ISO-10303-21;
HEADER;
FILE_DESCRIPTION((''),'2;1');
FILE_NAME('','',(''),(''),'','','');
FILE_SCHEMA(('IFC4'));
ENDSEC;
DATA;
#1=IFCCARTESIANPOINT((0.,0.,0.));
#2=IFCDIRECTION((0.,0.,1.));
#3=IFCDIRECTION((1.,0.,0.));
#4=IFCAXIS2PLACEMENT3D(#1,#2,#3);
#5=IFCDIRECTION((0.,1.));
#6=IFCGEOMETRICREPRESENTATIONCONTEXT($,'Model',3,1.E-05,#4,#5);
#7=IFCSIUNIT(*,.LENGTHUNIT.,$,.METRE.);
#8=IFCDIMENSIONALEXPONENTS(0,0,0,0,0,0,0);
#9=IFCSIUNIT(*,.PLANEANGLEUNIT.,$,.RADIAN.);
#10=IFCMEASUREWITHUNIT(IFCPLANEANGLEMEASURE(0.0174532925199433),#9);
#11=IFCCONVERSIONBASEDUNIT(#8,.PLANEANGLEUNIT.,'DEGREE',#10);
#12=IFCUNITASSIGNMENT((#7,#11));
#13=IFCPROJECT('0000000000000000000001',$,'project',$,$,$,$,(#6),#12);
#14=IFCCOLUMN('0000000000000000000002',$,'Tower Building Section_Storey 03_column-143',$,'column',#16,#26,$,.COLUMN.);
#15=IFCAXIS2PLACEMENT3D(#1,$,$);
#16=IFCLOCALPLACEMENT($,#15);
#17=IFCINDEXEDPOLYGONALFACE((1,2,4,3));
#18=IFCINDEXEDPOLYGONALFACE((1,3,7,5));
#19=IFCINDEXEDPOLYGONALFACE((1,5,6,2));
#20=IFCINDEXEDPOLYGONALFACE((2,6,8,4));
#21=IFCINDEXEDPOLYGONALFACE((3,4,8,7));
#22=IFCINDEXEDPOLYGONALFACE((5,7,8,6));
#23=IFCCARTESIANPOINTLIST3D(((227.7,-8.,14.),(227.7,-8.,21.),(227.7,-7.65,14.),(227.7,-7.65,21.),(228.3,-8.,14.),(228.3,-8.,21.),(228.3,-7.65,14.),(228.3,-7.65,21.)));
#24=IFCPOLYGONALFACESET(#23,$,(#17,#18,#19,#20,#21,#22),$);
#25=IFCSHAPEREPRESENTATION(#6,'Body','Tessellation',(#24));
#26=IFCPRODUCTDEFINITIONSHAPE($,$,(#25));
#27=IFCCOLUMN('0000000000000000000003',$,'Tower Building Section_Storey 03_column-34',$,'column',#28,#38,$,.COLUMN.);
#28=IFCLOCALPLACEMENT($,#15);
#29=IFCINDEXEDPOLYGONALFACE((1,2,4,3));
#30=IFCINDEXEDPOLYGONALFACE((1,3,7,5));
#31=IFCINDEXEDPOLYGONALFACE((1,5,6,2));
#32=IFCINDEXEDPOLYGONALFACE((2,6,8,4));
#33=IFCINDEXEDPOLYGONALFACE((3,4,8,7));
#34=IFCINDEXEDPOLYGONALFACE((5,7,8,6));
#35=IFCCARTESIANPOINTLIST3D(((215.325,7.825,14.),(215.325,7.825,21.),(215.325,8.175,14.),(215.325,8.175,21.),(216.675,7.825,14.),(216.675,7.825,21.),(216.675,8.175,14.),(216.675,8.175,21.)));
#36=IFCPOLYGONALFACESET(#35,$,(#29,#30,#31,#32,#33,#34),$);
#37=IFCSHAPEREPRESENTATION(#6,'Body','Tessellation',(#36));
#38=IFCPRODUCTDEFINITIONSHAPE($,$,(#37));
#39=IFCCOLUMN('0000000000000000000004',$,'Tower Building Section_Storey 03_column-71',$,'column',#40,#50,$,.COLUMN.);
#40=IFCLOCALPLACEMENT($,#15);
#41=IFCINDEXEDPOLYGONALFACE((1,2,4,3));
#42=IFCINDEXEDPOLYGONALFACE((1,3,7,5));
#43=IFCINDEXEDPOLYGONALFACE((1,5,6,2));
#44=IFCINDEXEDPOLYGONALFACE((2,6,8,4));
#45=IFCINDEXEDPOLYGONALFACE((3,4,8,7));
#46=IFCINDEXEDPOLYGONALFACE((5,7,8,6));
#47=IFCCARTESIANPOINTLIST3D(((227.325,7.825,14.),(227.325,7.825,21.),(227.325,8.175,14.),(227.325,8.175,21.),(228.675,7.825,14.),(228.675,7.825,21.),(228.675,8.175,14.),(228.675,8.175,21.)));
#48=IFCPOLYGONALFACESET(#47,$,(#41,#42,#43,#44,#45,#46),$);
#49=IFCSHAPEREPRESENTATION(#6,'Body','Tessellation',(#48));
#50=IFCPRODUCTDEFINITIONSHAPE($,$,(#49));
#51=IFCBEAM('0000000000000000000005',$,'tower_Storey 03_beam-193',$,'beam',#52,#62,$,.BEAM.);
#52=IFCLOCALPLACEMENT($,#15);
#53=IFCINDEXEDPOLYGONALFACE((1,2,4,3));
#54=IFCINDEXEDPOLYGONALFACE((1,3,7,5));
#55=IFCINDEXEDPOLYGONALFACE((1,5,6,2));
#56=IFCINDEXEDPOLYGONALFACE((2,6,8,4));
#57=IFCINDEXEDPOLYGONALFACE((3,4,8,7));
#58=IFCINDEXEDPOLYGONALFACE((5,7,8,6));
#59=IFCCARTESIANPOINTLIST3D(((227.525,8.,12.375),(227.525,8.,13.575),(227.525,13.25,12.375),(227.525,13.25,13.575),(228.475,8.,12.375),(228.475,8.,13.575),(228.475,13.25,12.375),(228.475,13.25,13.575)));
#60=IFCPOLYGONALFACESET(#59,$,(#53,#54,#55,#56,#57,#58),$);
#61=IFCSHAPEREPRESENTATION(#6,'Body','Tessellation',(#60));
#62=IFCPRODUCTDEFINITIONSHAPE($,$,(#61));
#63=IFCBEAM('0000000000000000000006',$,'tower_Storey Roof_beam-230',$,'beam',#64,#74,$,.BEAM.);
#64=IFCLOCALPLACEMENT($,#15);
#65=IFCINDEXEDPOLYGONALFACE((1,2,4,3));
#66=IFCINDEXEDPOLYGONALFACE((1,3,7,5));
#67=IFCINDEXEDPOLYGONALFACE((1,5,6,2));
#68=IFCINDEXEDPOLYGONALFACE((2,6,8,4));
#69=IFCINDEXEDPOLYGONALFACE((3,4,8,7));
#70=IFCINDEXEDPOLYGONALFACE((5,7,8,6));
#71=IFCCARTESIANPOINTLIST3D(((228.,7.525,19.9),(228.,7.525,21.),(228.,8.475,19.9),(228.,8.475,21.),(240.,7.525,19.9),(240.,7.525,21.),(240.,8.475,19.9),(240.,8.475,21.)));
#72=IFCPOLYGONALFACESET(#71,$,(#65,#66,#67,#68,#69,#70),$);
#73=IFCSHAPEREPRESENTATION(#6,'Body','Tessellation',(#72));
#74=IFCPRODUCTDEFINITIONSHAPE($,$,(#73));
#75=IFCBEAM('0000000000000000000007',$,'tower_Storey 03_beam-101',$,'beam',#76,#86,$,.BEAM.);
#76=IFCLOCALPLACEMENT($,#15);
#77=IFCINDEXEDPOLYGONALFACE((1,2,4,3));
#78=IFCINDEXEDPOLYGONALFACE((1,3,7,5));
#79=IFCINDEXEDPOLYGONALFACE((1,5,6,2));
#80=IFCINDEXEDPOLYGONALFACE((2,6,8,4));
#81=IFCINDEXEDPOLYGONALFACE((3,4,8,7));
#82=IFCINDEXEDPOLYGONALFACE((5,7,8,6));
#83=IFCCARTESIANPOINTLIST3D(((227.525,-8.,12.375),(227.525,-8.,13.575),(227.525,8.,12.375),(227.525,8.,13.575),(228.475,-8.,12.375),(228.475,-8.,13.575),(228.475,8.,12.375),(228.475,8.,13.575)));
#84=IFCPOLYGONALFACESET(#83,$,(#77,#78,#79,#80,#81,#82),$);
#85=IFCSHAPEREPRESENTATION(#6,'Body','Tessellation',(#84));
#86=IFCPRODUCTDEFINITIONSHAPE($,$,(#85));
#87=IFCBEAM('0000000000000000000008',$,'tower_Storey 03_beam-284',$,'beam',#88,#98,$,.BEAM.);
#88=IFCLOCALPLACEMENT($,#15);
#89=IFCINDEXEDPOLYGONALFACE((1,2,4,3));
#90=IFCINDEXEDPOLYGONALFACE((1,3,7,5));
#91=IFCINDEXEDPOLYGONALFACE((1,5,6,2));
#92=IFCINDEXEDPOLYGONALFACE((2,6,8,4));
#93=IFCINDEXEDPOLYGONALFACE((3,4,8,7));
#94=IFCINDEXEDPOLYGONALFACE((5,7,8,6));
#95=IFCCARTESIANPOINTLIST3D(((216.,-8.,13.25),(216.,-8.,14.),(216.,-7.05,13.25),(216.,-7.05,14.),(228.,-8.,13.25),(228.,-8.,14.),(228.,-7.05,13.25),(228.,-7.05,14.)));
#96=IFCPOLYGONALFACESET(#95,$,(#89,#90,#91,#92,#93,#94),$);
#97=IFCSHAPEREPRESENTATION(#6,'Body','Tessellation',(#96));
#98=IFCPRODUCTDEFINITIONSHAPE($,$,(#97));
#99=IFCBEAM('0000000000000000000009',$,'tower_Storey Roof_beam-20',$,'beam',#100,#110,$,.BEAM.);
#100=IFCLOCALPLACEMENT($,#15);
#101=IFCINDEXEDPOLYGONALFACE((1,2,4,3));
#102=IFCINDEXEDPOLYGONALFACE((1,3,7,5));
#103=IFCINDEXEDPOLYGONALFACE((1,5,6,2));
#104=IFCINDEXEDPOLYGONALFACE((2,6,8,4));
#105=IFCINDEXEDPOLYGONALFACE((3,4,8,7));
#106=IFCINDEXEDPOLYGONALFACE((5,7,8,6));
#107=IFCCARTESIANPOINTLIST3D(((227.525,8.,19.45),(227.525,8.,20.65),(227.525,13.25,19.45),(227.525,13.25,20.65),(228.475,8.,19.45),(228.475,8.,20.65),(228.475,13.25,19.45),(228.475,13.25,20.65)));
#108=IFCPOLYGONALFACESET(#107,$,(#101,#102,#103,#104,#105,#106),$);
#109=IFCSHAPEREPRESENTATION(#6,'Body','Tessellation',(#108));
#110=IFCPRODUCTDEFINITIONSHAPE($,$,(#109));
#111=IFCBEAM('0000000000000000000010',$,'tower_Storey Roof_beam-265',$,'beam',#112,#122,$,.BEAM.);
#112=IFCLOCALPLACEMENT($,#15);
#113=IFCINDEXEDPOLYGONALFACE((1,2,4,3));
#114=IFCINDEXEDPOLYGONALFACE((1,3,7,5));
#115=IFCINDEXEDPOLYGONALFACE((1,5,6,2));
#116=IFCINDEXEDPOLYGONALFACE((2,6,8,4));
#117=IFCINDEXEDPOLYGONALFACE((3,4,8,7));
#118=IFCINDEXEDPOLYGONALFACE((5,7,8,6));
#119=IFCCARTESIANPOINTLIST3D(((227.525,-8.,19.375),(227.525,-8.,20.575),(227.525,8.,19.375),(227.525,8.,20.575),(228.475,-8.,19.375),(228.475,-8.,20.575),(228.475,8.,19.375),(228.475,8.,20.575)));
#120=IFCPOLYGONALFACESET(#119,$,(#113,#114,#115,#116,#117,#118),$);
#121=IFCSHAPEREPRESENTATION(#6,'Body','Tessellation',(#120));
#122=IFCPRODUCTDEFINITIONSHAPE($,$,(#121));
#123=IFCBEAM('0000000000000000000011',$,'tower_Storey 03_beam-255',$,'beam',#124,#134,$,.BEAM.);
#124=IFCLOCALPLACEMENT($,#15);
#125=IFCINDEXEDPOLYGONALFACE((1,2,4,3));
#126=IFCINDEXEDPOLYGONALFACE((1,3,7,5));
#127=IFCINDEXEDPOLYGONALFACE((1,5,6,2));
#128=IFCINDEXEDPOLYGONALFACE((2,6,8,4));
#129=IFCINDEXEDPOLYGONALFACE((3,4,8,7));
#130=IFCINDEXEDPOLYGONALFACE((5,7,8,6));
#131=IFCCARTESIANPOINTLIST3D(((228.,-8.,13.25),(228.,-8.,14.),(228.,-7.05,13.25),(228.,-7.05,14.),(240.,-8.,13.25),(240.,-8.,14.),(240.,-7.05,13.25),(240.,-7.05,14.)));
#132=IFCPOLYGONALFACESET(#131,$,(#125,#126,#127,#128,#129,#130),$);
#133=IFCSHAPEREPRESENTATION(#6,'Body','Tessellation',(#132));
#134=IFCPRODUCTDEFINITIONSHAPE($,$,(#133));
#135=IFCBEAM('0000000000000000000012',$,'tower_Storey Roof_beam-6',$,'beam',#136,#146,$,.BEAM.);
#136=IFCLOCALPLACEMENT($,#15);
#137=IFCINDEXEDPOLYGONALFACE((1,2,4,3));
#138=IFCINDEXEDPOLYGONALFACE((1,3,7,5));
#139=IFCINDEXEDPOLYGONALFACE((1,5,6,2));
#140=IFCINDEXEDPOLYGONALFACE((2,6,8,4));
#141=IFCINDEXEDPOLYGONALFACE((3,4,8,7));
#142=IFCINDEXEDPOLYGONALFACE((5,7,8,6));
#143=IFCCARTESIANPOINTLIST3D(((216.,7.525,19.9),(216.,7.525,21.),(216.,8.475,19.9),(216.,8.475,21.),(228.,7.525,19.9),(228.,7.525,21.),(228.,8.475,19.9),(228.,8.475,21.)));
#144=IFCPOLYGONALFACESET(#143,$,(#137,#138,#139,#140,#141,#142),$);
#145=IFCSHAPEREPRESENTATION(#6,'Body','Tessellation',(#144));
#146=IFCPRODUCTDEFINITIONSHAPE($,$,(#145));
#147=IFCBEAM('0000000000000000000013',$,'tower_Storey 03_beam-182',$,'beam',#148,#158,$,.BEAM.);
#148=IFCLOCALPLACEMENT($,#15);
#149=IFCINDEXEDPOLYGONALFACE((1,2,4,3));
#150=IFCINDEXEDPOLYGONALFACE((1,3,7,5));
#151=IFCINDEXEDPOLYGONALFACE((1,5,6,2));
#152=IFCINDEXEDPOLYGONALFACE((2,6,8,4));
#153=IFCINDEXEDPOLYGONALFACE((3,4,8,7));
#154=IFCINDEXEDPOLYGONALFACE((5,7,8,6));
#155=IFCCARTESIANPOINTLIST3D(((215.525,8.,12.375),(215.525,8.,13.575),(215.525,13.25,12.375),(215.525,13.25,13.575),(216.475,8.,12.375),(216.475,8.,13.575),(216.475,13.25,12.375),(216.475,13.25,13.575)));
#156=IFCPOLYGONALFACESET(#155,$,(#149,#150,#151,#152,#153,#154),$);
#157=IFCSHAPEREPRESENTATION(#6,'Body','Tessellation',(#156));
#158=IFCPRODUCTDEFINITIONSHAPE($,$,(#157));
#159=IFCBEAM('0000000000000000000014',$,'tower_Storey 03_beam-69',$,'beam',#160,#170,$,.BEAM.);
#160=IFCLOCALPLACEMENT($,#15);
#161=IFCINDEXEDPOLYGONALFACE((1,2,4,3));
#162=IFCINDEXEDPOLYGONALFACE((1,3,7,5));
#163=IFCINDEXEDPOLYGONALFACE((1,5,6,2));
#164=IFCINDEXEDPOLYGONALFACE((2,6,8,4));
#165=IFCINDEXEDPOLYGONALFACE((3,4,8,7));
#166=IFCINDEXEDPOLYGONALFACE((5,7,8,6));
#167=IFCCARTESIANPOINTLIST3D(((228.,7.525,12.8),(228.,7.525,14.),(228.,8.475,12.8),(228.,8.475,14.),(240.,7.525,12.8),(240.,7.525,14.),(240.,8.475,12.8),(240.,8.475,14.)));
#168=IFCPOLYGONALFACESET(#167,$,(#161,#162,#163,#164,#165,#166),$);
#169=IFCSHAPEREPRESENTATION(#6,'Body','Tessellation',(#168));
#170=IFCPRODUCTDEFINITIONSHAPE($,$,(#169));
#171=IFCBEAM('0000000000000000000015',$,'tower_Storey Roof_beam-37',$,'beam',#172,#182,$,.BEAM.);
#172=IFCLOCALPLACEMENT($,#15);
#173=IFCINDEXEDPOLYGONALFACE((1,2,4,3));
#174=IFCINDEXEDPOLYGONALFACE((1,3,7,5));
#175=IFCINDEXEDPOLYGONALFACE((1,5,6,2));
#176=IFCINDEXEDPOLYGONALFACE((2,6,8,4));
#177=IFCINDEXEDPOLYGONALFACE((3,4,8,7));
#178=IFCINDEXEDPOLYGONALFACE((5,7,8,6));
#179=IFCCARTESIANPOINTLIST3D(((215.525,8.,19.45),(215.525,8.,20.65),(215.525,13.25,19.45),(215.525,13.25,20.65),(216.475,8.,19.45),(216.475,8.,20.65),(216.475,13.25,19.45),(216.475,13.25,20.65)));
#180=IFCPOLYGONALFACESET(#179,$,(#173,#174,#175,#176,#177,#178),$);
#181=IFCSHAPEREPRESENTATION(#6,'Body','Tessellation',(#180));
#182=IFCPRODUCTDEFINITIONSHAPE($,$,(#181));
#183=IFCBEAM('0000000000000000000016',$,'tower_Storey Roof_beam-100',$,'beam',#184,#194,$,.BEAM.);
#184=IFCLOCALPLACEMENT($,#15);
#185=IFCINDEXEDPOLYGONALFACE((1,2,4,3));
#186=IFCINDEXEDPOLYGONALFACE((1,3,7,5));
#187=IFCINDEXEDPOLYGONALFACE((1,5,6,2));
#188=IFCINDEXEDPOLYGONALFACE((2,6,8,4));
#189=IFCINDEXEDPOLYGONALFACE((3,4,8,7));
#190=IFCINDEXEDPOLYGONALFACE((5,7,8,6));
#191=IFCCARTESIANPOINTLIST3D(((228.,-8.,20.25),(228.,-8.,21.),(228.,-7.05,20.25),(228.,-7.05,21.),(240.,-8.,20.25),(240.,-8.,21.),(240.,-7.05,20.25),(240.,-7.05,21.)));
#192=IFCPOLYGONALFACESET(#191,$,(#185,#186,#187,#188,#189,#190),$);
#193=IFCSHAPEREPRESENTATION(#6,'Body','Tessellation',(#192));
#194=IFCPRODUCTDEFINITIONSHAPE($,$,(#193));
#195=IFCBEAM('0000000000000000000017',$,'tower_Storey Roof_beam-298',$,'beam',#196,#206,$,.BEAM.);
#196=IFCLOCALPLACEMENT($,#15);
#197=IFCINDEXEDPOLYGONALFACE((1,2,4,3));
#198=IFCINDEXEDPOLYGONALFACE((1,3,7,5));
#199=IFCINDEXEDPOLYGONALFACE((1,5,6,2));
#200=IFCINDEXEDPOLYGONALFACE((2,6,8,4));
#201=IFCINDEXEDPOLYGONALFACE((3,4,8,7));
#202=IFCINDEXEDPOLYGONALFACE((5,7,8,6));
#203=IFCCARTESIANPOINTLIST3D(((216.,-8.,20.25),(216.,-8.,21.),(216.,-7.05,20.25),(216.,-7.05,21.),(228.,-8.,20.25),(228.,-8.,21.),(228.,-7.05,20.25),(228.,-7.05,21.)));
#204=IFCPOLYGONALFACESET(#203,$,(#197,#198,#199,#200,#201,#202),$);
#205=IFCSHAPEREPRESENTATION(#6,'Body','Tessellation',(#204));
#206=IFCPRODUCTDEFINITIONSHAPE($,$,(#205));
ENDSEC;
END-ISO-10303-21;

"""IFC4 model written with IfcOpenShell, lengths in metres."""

from ifc_helpers import new_model, entity, si_unit, converted_unit, direction, frame, origin_with_axes, place, context, project, polyline, outline, extrude, element, save


model = new_model("IFC4")

# Units and contexts
model_context = context("Model", 3, precision=1e-05, world=origin_with_axes(), true_north=direction((0.0, 1.0)))
ifc_project = project(units=[si_unit("LENGTHUNIT", "METRE"), converted_unit("PLANEANGLEUNIT", "DEGREE", entity("IfcPlaneAngleMeasure", 0.0174532925199433), si_unit("PLANEANGLEUNIT", "RADIAN"), dimensions=[0, 0, 0, 0, 0, 0, 0])], contexts=[model_context])

# Columns
placement_1 = place(None, origin_with_axes())
placement_2 = place(placement_1, frame((0.0, 0.0, 14.0), z_axis=(0.0, 0.0, 1.0), x_axis=(1.0, 0.0, 0.0)))
column_placement = place(placement_2, frame((228.0, -7.825, 0.0), z_axis=(0.0, 0.0, 1.0), x_axis=(1.0, 0.0, 0.0)))
element("IfcColumn", 1, at=column_placement, Name="Tower Building Section_Storey 03_column-143", ObjectType="column", PredefinedType="COLUMN", context=model_context, body=[
    extrude(outline(polyline([(-0.3, -0.175, 0.0), (0.3, -0.175, 0.0), (0.3, 0.175, 0.0), (-0.3, 0.175, 0.0), (-0.3, -0.175, 0.0)])), origin_with_axes(), (0.0, 0.0, 1.0), 7.0),
])
for number, where, z_axis, x_axis, name in (
    (2, (216.0, 8.0, 0.0), (0.0, 0.0, 1.0), (1.0, 0.0, 0.0), "Tower Building Section_Storey 03_column-34"),
    (3, (228.0, 8.0, 0.0), (0.0, 0.0, 1.0), (1.0, 0.0, 0.0), "Tower Building Section_Storey 03_column-71"),
):
    element("IfcColumn", number, at=place(placement_2, frame(where, z_axis=z_axis, x_axis=x_axis)), Name=name, ObjectType="column", PredefinedType="COLUMN", context=model_context, body=[
        extrude(outline(polyline([(-0.675, -0.175, 0.0), (0.675, -0.175, 0.0), (0.675, 0.175, 0.0), (-0.675, 0.175, 0.0), (-0.675, -0.175, 0.0)])), origin_with_axes(), (0.0, 0.0, 1.0), 7.0),
    ])

# Beams
beam_1_placement = place(placement_2, frame((228.0, 8.0, -1.025), z_axis=(0.0, 1.0, 0.0), x_axis=(-1.0, 0.0, 0.0)))
element("IfcBeam", 4, at=beam_1_placement, Name="tower_Storey 03_beam-193", ObjectType="beam", PredefinedType="BEAM", context=model_context, body=[
    extrude(outline(polyline([(0.475, 0.6, 0.0), (-0.475, 0.6, 0.0), (-0.475, -0.6, 0.0), (0.475, -0.6, 0.0), (0.475, 0.6, 0.0)])), origin_with_axes(), (0.0, 0.0, 1.0), 5.25),
])
placement_3 = place(placement_1, frame((0.0, 0.0, 21.0), z_axis=(0.0, 0.0, 1.0), x_axis=(1.0, 0.0, 0.0)))
beam_2_placement = place(placement_3, frame((228.0, 8.0, -0.55), z_axis=(1.0, 0.0, 0.0), x_axis=(0.0, 1.0, 0.0)))
element("IfcBeam", 5, at=beam_2_placement, Name="tower_Storey Roof_beam-230", ObjectType="beam", PredefinedType="BEAM", context=model_context, body=[
    extrude(outline(polyline([(0.475, 0.55, 0.0), (-0.475, 0.55, 0.0), (-0.475, -0.55, 0.0), (0.475, -0.55, 0.0), (0.475, 0.55, 0.0)])), origin_with_axes(), (0.0, 0.0, 1.0), 12.0),
])
beam_3_placement = place(placement_2, frame((228.0, -8.0, -1.025), z_axis=(0.0, 1.0, 0.0), x_axis=(-1.0, 0.0, 0.0)))
element("IfcBeam", 6, at=beam_3_placement, Name="tower_Storey 03_beam-101", ObjectType="beam", PredefinedType="BEAM", context=model_context, body=[
    extrude(outline(polyline([(0.475, 0.6, 0.0), (-0.475, 0.6, 0.0), (-0.475, -0.6, 0.0), (0.475, -0.6, 0.0), (0.475, 0.6, 0.0)])), origin_with_axes(), (0.0, 0.0, 1.0), 16.0),
])
beam_4_placement = place(placement_2, frame((216.0, -7.525, -0.375), z_axis=(1.0, 0.0, 0.0), x_axis=(0.0, 1.0, 0.0)))
element("IfcBeam", 7, at=beam_4_placement, Name="tower_Storey 03_beam-284", ObjectType="beam", PredefinedType="BEAM", context=model_context, body=[
    extrude(outline(polyline([(0.475, 0.375, 0.0), (-0.475, 0.375, 0.0), (-0.475, -0.375, 0.0), (0.475, -0.375, 0.0), (0.475, 0.375, 0.0)])), origin_with_axes(), (0.0, 0.0, 1.0), 12.0),
])
beam_5_placement = place(placement_3, frame((228.0, 8.0, -0.95), z_axis=(0.0, 1.0, 0.0), x_axis=(-1.0, 0.0, 0.0)))
element("IfcBeam", 8, at=beam_5_placement, Name="tower_Storey Roof_beam-20", ObjectType="beam", PredefinedType="BEAM", context=model_context, body=[
    extrude(outline(polyline([(0.475, 0.6, 0.0), (-0.475, 0.6, 0.0), (-0.475, -0.6, 0.0), (0.475, -0.6, 0.0), (0.475, 0.6, 0.0)])), origin_with_axes(), (0.0, 0.0, 1.0), 5.25),
])
beam_6_placement = place(placement_3, frame((228.0, -8.0, -1.025), z_axis=(0.0, 1.0, 0.0), x_axis=(-1.0, 0.0, 0.0)))
element("IfcBeam", 9, at=beam_6_placement, Name="tower_Storey Roof_beam-265", ObjectType="beam", PredefinedType="BEAM", context=model_context, body=[
    extrude(outline(polyline([(0.475, 0.6, 0.0), (-0.475, 0.6, 0.0), (-0.475, -0.6, 0.0), (0.475, -0.6, 0.0), (0.475, 0.6, 0.0)])), origin_with_axes(), (0.0, 0.0, 1.0), 16.0),
])
beam_7_placement = place(placement_2, frame((228.0, -7.525, -0.375), z_axis=(1.0, 0.0, 0.0), x_axis=(0.0, 1.0, 0.0)))
element("IfcBeam", 10, at=beam_7_placement, Name="tower_Storey 03_beam-255", ObjectType="beam", PredefinedType="BEAM", context=model_context, body=[
    extrude(outline(polyline([(0.475, 0.375, 0.0), (-0.475, 0.375, 0.0), (-0.475, -0.375, 0.0), (0.475, -0.375, 0.0), (0.475, 0.375, 0.0)])), origin_with_axes(), (0.0, 0.0, 1.0), 12.0),
])
beam_8_placement = place(placement_3, frame((216.0, 8.0, -0.55), z_axis=(1.0, 0.0, 0.0), x_axis=(0.0, 1.0, 0.0)))
element("IfcBeam", 11, at=beam_8_placement, Name="tower_Storey Roof_beam-6", ObjectType="beam", PredefinedType="BEAM", context=model_context, body=[
    extrude(outline(polyline([(0.475, 0.55, 0.0), (-0.475, 0.55, 0.0), (-0.475, -0.55, 0.0), (0.475, -0.55, 0.0), (0.475, 0.55, 0.0)])), origin_with_axes(), (0.0, 0.0, 1.0), 12.0),
])
beam_9_placement = place(placement_2, frame((216.0, 8.0, -1.025), z_axis=(0.0, 1.0, 0.0), x_axis=(-1.0, 0.0, 0.0)))
element("IfcBeam", 12, at=beam_9_placement, Name="tower_Storey 03_beam-182", ObjectType="beam", PredefinedType="BEAM", context=model_context, body=[
    extrude(outline(polyline([(0.475, 0.6, 0.0), (-0.475, 0.6, 0.0), (-0.475, -0.6, 0.0), (0.475, -0.6, 0.0), (0.475, 0.6, 0.0)])), origin_with_axes(), (0.0, 0.0, 1.0), 5.25),
])
beam_10_placement = place(placement_2, frame((228.0, 8.0, -0.6), z_axis=(1.0, 0.0, 0.0), x_axis=(0.0, 1.0, 0.0)))
element("IfcBeam", 13, at=beam_10_placement, Name="tower_Storey 03_beam-69", ObjectType="beam", PredefinedType="BEAM", context=model_context, body=[
    extrude(outline(polyline([(0.475, 0.6, 0.0), (-0.475, 0.6, 0.0), (-0.475, -0.6, 0.0), (0.475, -0.6, 0.0), (0.475, 0.6, 0.0)])), origin_with_axes(), (0.0, 0.0, 1.0), 12.0),
])
beam_11_placement = place(placement_3, frame((216.0, 8.0, -0.95), z_axis=(0.0, 1.0, 0.0), x_axis=(-1.0, 0.0, 0.0)))
element("IfcBeam", 14, at=beam_11_placement, Name="tower_Storey Roof_beam-37", ObjectType="beam", PredefinedType="BEAM", context=model_context, body=[
    extrude(outline(polyline([(0.475, 0.6, 0.0), (-0.475, 0.6, 0.0), (-0.475, -0.6, 0.0), (0.475, -0.6, 0.0), (0.475, 0.6, 0.0)])), origin_with_axes(), (0.0, 0.0, 1.0), 5.25),
])
for number, where, z_axis, x_axis, name in (
    (15, (228.0, -7.525, -0.375), (1.0, 0.0, 0.0), (0.0, 1.0, 0.0), "tower_Storey Roof_beam-100"),
    (16, (216.0, -7.525, -0.375), (1.0, 0.0, 0.0), (0.0, 1.0, 0.0), "tower_Storey Roof_beam-298"),
):
    element("IfcBeam", number, at=place(placement_3, frame(where, z_axis=z_axis, x_axis=x_axis)), Name=name, ObjectType="beam", PredefinedType="BEAM", context=model_context, body=[
        extrude(outline(polyline([(0.475, 0.375, 0.0), (-0.475, 0.375, 0.0), (-0.475, -0.375, 0.0), (0.475, -0.375, 0.0), (0.475, 0.375, 0.0)])), origin_with_axes(), (0.0, 0.0, 1.0), 12.0),
    ])

save(model, "model.ifc")
